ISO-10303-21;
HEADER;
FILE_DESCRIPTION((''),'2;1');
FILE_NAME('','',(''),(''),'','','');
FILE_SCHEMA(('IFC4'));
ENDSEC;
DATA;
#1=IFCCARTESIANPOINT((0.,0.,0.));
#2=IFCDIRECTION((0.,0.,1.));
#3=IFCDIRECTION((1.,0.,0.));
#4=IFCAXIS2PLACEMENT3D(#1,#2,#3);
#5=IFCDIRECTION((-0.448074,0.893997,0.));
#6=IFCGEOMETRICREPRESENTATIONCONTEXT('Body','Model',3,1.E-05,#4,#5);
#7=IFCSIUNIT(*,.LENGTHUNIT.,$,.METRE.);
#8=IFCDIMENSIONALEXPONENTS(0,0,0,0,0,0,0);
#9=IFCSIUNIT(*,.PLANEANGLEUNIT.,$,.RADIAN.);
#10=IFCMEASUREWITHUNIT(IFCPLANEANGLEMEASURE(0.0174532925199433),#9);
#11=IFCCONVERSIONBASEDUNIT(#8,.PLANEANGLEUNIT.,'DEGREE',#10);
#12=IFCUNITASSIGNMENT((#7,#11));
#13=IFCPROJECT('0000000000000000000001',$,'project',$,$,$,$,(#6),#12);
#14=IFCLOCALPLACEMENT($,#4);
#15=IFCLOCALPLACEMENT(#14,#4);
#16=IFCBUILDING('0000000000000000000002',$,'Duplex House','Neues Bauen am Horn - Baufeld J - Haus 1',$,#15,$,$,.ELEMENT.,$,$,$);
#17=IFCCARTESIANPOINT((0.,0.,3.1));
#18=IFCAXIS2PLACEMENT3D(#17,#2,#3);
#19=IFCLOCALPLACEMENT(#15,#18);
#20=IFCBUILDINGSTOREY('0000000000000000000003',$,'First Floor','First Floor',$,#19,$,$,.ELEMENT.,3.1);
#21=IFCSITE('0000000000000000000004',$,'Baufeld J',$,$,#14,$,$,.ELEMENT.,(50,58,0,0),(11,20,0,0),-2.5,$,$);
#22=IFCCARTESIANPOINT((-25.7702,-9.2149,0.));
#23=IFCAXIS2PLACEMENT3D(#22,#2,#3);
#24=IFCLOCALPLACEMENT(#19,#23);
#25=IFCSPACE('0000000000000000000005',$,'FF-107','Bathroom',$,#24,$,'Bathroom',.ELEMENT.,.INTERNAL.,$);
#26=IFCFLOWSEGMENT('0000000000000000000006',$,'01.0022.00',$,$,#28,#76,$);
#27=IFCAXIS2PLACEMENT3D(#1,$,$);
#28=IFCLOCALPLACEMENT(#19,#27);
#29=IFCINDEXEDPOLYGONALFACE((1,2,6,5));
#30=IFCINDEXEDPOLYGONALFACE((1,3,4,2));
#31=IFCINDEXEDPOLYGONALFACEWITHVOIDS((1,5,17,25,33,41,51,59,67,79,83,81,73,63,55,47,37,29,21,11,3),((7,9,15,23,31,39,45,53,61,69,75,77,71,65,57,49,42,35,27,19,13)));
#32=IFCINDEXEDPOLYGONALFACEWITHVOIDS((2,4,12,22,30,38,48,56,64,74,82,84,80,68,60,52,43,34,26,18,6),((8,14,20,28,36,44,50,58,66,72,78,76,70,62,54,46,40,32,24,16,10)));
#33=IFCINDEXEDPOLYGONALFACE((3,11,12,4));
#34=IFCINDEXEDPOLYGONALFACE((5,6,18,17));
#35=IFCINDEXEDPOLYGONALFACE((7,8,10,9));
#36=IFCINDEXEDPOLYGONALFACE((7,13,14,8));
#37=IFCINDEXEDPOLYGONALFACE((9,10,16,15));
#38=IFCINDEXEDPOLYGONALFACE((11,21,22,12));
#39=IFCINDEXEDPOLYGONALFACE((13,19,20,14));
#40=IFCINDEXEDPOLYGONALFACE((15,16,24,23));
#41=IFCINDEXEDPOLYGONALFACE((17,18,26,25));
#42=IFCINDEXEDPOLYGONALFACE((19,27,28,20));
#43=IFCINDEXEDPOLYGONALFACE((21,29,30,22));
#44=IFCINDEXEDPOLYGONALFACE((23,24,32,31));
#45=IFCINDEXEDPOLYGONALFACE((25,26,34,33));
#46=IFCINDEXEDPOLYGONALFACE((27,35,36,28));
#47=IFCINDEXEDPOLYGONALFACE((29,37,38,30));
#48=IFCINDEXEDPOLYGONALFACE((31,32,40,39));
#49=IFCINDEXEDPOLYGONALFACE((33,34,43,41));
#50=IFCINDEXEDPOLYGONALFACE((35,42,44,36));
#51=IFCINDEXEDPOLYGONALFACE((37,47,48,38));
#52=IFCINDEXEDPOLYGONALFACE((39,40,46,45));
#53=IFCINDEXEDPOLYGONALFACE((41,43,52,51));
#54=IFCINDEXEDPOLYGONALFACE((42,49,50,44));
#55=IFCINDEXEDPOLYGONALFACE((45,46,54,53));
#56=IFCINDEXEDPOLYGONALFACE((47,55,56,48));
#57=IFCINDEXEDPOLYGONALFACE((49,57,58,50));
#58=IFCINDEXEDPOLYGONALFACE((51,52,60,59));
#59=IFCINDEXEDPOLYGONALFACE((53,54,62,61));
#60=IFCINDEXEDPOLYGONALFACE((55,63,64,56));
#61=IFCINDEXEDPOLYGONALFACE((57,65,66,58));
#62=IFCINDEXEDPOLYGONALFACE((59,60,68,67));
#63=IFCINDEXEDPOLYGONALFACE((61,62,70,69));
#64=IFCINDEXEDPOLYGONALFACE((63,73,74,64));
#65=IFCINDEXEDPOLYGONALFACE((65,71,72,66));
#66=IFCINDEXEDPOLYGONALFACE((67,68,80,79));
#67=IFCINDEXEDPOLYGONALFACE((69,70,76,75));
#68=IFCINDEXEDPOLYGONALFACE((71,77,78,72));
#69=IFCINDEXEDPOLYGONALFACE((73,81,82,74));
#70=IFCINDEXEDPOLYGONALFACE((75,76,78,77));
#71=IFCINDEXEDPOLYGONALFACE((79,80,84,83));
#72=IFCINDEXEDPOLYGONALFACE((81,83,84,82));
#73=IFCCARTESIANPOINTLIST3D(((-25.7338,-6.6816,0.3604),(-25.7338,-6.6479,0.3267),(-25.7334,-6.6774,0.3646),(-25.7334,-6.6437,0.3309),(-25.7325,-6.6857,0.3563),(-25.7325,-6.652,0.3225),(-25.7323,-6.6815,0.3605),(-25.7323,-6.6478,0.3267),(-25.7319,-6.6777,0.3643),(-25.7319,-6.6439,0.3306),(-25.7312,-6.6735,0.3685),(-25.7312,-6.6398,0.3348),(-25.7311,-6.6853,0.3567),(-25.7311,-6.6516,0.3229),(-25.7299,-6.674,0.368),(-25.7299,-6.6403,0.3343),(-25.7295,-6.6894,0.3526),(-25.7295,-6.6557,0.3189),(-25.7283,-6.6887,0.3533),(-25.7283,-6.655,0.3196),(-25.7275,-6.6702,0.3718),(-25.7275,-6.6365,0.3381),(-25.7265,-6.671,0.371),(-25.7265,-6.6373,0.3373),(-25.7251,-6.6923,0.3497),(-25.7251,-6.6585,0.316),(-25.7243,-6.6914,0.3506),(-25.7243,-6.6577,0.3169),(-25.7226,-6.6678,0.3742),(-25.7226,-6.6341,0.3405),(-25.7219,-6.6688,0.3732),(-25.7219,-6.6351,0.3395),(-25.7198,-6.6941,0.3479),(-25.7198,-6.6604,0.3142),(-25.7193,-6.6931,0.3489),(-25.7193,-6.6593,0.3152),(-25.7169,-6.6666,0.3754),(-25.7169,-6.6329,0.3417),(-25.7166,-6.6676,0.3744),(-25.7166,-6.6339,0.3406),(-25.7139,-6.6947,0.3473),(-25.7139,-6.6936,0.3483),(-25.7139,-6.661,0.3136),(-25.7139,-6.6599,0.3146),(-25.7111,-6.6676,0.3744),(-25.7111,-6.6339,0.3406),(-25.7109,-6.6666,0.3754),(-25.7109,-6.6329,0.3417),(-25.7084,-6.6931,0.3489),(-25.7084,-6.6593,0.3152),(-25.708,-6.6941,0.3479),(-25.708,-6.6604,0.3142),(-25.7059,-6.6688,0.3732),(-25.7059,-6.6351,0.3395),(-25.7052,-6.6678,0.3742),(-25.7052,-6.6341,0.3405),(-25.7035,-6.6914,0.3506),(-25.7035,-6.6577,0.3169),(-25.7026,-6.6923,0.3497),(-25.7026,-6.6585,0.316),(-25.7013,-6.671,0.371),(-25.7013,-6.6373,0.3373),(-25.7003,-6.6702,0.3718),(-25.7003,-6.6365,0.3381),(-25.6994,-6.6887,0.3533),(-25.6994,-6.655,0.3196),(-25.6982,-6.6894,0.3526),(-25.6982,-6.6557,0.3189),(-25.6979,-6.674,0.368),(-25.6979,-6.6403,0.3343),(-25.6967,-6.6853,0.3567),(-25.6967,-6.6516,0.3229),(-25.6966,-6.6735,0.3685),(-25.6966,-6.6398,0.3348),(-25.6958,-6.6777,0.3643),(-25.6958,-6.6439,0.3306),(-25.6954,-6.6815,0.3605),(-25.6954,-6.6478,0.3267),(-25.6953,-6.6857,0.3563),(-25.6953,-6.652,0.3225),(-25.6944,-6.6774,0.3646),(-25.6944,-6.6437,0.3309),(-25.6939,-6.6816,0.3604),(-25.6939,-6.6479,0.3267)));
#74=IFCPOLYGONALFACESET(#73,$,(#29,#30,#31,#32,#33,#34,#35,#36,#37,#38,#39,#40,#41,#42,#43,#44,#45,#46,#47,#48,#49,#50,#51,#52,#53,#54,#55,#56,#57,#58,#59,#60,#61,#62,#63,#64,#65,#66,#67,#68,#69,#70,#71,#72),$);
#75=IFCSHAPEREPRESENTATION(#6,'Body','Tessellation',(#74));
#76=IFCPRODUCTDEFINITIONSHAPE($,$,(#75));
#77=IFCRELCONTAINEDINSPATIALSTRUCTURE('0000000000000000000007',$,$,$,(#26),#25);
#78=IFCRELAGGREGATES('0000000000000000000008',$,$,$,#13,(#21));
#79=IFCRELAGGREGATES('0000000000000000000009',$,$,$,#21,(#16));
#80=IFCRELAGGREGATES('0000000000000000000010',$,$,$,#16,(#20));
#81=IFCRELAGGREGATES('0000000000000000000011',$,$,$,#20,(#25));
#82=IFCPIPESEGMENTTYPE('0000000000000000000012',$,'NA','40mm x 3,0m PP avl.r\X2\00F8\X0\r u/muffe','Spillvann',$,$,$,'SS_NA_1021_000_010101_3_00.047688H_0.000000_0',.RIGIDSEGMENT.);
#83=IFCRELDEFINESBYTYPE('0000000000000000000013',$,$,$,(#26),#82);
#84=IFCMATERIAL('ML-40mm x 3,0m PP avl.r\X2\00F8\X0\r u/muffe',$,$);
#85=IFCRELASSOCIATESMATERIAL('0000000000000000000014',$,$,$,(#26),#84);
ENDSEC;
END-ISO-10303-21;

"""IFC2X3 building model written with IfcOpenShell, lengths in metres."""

from ifc_helpers import new_model, entity, si_unit, converted_unit, direction, frame, origin_with_axes, origin_2d_with_axis, place, context, project, spatial, hollow_circle, extrude, material, type_object, element, save


model = new_model("IFC2X3")

# Units and contexts
model_context = context("Model", 3, precision=1e-05, world=origin_with_axes(), true_north=direction((-0.448074, 0.893997, 0.0)), identifier="Body")
ifc_project = project(units=[si_unit("LENGTHUNIT", "METRE"), converted_unit("PLANEANGLEUNIT", "DEGREE", entity("IfcPlaneAngleMeasure", 0.0174532925199433), si_unit("PLANEANGLEUNIT", "RADIAN"), dimensions=[0, 0, 0, 0, 0, 0, 0])], contexts=[model_context])

# Site, building, storey
site_placement = place(None, origin_with_axes())
site = spatial("IfcSite", under=ifc_project, at=site_placement, Name="Baufeld J", CompositionType="ELEMENT", RefLatitude=(50, 58, 0, 0), RefLongitude=(11, 20, 0, 0), RefElevation=-2.5)
building_placement = place(site_placement, origin_with_axes())
building = spatial("IfcBuilding", under=site, at=building_placement, Name="Duplex House", Description="Neues Bauen am Horn - Baufeld J - Haus 1", CompositionType="ELEMENT")
storey_placement = place(building_placement, frame((0.0, 0.0, 3.1), z_axis=(0.0, 0.0, 1.0), x_axis=(1.0, 0.0, 0.0)))
storey = spatial("IfcBuildingStorey", under=building, at=storey_placement, Name="First Floor", Description="First Floor", CompositionType="ELEMENT", Elevation=3.1)

# Shared definitions
ifc_material_1 = material(Name="ML-40mm x 3,0m PP avl.rør u/muffe")

# Shared definitions
space_1_placement = place(storey_placement, frame((-25.7702, -9.2149, 0.0), z_axis=(0.0, 0.0, 1.0), x_axis=(1.0, 0.0, 0.0)))
space_1 = spatial("IfcSpace", under=storey, at=space_1_placement, Name="FF-107", Description="Bathroom", LongName="Bathroom", CompositionType="ELEMENT", InteriorOrExteriorSpace="INTERNAL")

# Flow segment
pipe_segment_type_1 = type_object("IfcPipeSegmentType", Name="NA", Description="40mm x 3,0m PP avl.rør u/muffe", ApplicableOccurrence="Spillvann", ElementType="SS_NA_1021_000_010101_3_00.047688H_0.000000_0", PredefinedType="RIGIDSEGMENT")
flow_segment_1_placement = place(space_1_placement, frame((0.0563, 2.5681, 0.3277), z_axis=(0.0, 0.707107, 0.707107), x_axis=(0.0, -0.707107, 0.707107)))
element("IfcFlowSegment", 1, at=flow_segment_1_placement, inside=space_1, type_object=pipe_segment_type_1, material=ifc_material_1, Name="01.0022.00", context=model_context, shape_type="SweptSolid", body=[
    extrude(hollow_circle(Radius=0.02, WallThickness=0.0015, at=origin_2d_with_axis()), frame((0.0, 0.0, 0.0), z_axis=(1.0, 0.0, 0.0), x_axis=(0.0, 0.0, -1.0)), (0.0, 0.0, 1.0), 0.0477),
])

save(model, "model.ifc")
